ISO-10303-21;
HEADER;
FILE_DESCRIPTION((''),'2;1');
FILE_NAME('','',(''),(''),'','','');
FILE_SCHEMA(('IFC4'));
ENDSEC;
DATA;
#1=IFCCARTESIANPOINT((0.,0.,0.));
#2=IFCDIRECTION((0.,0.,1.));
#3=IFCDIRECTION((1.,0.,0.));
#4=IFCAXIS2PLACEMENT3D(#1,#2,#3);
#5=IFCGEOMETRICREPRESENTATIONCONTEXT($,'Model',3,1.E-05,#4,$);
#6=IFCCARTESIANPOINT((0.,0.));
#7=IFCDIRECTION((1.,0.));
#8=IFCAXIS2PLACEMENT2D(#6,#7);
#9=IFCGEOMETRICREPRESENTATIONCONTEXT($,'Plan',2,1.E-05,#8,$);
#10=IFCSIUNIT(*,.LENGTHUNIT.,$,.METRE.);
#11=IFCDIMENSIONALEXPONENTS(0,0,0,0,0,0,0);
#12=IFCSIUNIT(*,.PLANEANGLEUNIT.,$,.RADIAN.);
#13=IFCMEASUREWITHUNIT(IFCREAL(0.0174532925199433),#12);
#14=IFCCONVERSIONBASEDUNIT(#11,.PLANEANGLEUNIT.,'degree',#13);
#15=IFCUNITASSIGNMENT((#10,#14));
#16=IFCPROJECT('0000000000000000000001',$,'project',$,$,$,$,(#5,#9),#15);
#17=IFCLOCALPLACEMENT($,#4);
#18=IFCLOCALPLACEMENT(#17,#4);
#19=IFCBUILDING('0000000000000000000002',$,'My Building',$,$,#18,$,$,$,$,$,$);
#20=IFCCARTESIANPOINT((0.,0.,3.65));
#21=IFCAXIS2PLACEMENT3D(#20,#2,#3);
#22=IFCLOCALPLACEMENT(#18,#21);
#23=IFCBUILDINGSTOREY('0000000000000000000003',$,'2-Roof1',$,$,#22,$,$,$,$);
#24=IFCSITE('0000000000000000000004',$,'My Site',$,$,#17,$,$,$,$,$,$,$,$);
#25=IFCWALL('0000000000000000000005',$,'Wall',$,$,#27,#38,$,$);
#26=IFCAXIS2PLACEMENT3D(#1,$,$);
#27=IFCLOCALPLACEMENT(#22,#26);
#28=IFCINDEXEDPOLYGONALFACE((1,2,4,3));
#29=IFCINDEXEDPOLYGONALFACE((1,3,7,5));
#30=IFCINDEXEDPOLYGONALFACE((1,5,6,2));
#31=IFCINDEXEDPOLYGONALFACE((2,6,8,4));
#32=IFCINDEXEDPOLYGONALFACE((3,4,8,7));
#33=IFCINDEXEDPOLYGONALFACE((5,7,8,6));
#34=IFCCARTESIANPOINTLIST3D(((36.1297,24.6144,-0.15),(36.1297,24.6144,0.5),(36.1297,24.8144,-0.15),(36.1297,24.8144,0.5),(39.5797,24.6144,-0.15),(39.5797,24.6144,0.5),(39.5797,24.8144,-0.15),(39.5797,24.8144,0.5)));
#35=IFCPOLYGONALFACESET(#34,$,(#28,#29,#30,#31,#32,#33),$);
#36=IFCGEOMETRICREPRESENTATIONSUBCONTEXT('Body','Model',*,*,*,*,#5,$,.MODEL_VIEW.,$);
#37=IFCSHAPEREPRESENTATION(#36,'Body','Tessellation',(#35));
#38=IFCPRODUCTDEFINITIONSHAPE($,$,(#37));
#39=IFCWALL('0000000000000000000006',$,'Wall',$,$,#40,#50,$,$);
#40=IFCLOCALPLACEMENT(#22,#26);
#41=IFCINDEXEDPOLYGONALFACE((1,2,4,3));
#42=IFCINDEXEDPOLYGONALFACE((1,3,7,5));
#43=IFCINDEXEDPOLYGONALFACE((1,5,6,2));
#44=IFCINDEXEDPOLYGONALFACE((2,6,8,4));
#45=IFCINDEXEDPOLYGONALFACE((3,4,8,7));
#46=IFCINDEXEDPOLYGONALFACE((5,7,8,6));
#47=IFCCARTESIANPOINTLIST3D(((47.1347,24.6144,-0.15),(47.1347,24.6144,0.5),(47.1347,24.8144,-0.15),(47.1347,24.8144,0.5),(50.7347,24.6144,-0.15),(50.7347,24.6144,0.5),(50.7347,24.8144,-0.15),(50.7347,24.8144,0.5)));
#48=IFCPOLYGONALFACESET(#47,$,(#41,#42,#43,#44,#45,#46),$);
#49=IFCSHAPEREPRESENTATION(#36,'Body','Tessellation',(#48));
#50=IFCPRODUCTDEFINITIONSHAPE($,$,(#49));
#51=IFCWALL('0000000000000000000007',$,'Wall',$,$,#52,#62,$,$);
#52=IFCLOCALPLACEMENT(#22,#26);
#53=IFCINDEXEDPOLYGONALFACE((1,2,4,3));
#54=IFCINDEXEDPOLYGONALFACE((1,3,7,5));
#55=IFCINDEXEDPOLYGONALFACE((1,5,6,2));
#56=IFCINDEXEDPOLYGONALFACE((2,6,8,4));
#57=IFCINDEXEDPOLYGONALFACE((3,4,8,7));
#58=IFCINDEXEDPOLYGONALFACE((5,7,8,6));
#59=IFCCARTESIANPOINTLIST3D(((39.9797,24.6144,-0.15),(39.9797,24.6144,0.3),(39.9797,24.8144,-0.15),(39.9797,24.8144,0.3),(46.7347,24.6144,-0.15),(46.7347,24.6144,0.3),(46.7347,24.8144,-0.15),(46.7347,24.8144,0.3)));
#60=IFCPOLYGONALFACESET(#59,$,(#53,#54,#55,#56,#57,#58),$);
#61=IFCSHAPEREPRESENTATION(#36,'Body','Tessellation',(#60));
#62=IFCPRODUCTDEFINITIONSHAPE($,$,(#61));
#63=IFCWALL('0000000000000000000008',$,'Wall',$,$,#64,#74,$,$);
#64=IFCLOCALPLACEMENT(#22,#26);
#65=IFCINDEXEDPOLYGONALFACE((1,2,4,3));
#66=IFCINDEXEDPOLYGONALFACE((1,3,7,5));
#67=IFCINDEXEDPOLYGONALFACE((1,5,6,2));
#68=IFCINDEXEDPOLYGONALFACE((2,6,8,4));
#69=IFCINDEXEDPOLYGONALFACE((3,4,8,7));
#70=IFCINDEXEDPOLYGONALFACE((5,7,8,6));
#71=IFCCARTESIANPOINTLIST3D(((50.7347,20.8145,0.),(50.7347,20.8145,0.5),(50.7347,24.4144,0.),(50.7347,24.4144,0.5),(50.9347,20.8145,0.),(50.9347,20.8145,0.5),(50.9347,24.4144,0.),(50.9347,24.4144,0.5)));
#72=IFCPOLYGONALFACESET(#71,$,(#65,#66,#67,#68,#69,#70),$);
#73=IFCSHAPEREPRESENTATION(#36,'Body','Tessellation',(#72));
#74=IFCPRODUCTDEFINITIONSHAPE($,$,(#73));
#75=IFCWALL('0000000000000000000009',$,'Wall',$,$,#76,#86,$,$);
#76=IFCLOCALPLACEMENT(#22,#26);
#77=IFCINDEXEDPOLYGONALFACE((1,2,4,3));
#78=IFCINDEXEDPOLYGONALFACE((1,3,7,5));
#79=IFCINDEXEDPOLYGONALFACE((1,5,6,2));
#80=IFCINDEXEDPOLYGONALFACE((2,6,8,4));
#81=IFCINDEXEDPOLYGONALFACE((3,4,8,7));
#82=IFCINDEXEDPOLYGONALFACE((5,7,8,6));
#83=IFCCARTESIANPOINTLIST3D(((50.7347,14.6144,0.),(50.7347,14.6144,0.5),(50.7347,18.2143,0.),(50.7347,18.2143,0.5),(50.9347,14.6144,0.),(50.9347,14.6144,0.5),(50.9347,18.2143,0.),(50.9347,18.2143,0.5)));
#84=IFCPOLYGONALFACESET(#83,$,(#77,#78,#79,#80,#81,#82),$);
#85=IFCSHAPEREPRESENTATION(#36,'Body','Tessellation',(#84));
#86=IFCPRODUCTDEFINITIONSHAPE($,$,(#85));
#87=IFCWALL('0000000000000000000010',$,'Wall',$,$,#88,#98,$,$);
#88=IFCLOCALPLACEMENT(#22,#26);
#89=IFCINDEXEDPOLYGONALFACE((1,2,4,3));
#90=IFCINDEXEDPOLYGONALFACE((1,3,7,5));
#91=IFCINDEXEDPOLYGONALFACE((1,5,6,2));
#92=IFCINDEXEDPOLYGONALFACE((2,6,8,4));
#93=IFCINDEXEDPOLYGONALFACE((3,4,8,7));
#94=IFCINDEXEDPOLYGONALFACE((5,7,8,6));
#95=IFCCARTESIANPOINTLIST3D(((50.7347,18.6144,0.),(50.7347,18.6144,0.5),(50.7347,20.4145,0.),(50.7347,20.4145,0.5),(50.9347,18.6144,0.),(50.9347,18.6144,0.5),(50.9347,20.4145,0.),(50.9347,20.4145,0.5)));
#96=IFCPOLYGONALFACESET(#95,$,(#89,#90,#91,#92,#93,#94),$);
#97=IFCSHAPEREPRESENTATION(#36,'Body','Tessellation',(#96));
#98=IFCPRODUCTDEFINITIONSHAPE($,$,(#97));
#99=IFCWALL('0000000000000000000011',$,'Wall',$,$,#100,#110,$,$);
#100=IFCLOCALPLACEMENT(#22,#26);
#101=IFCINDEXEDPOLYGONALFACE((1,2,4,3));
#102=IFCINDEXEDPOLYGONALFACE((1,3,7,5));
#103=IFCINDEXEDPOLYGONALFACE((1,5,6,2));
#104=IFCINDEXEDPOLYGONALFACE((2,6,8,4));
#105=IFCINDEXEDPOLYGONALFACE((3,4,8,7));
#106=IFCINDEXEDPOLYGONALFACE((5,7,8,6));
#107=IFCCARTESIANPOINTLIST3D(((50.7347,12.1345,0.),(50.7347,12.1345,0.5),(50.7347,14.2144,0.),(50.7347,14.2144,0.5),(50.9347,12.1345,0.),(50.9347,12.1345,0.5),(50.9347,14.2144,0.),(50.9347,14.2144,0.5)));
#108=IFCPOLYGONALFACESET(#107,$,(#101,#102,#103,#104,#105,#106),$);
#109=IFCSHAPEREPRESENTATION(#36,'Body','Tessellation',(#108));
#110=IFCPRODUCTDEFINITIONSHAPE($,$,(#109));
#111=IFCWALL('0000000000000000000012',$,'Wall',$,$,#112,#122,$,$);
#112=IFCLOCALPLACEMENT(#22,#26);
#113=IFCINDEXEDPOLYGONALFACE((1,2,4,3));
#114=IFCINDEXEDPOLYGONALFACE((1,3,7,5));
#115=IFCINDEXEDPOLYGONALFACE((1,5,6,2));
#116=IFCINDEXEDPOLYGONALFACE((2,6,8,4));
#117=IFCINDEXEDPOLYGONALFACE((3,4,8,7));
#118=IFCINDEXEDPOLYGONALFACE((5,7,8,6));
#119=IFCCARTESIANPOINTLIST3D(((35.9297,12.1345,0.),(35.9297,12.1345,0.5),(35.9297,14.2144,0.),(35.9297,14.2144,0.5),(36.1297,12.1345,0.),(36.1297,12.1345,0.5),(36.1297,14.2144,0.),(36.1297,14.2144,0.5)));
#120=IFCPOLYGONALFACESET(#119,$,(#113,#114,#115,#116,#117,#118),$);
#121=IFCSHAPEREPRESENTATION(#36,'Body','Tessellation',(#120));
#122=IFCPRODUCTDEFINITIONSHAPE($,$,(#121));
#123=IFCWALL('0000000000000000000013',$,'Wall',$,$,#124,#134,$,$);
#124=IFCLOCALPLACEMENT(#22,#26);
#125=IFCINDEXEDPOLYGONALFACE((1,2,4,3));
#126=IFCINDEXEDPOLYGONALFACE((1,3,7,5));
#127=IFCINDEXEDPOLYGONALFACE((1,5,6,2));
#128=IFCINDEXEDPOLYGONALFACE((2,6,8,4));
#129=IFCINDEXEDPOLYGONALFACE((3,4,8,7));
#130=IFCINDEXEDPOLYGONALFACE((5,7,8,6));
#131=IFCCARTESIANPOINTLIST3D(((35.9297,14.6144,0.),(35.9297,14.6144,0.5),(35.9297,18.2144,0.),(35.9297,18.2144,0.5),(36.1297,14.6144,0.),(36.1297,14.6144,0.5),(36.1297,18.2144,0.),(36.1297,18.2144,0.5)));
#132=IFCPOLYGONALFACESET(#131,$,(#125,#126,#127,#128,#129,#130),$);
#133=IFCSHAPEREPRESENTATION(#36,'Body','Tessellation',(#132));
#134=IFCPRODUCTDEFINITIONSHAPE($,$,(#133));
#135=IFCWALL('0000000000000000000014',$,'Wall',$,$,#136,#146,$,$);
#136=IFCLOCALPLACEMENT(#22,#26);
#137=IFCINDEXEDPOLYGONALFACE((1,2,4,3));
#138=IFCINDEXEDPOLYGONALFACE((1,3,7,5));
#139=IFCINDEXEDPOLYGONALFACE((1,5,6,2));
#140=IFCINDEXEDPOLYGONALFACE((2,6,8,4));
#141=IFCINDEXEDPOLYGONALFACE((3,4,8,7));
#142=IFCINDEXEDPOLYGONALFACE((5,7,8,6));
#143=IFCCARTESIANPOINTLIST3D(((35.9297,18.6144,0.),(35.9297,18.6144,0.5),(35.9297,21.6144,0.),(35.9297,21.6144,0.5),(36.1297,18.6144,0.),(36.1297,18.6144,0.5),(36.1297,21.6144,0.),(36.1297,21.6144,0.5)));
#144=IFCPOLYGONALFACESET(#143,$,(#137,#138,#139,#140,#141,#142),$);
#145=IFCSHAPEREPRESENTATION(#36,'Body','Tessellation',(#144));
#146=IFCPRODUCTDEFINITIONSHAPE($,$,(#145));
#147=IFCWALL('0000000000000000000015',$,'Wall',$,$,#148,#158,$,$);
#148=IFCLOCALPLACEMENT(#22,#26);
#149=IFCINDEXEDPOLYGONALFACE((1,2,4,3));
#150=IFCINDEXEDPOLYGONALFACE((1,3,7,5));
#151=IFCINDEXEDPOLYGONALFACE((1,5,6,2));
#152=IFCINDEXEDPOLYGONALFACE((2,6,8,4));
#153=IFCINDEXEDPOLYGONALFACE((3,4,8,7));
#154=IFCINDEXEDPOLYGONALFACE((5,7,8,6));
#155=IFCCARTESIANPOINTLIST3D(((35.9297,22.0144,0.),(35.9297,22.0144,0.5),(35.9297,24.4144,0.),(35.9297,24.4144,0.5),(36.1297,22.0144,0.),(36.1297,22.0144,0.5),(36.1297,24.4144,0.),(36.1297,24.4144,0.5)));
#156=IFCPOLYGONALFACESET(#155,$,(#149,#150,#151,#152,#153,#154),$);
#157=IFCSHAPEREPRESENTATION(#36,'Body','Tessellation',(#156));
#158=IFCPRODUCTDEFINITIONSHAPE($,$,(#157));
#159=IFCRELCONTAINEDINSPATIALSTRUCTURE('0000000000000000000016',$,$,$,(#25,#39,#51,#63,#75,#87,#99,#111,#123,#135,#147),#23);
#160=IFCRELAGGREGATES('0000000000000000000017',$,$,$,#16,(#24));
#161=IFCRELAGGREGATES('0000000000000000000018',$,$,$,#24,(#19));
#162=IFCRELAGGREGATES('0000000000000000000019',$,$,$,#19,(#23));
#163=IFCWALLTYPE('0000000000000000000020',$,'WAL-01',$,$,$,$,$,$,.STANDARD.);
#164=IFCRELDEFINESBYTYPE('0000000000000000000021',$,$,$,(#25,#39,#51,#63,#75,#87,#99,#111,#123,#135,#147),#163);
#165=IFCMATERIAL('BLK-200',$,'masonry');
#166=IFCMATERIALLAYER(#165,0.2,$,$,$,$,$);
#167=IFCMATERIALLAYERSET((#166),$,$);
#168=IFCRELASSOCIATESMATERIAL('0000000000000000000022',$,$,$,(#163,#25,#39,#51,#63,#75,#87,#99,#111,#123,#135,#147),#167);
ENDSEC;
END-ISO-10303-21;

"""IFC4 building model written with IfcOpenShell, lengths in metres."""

from ifc_helpers import new_model, entity, si_unit, converted_unit, frame, origin_with_axes, origin_2d_with_axis, place, context, subcontext, project, spatial, indexed_curve, outline, extrude, material, layer, layer_set, layer_usage, type_object, element, save


model = new_model("IFC4")

# Units and contexts
model_context = context("Model", 3, precision=1e-05, world=origin_with_axes())
plan_context = context("Plan", 2, precision=1e-05, world=origin_2d_with_axis())
body_context = subcontext(model_context, "Body", "Model", "MODEL_VIEW")
ifc_project = project(units=[si_unit("LENGTHUNIT", "METRE"), converted_unit("PLANEANGLEUNIT", "degree", entity("IfcReal", 0.0174532925199433), si_unit("PLANEANGLEUNIT", "RADIAN"), dimensions=[0, 0, 0, 0, 0, 0, 0])], contexts=[model_context, plan_context])

# Site, building, storey
site_placement = place(None, origin_with_axes())
site = spatial("IfcSite", under=ifc_project, at=site_placement, Name="My Site")
building_placement = place(site_placement, origin_with_axes())
building = spatial("IfcBuilding", under=site, at=building_placement, Name="My Building")
storey_placement = place(building_placement, frame((0.0, 0.0, 3.65), z_axis=(0.0, 0.0, 1.0), x_axis=(1.0, 0.0, 0.0)))
storey = spatial("IfcBuildingStorey", under=building, at=storey_placement, Name="2-Roof1")

# Walls
ifc_material = material(Name="BLK-200", Category="masonry")
ifc_layer = layer(ifc_material, 0.2)
ifc_layer_set = layer_set([ifc_layer])
ifc_layer_usage_1 = layer_usage(ifc_layer_set, "AXIS2", "POSITIVE", 0.0)
wall_type = type_object("IfcWallType", Name="WAL-01", PredefinedType="STANDARD", material=ifc_layer_set)
wall_1_placement = place(storey_placement, frame((39.5797, 24.8144, -0.15), z_axis=(0.0, 0.0, 1.0), x_axis=(-1.0, 0.0, 0.0)))
element("IfcWall", 1, at=wall_1_placement, inside=storey, type_object=wall_type, material=ifc_layer_usage_1, Name="Wall", context=body_context, shape_type="SweptSolid", body=[
    extrude(outline(indexed_curve([(0.0, 0.0), (0.0, 0.2), (3.45, 0.2), (3.45, 0.0), (0.0, 0.0)], self_intersect=False)), origin_with_axes(), (0.0, 0.0, 1.0), 0.65),
])
ifc_layer_usage_2 = layer_usage(ifc_layer_set, "AXIS2", "POSITIVE", 0.0)
wall_2_placement = place(storey_placement, frame((50.7347, 24.8144, -0.15), z_axis=(0.0, 0.0, 1.0), x_axis=(-1.0, 0.0, 0.0)))
element("IfcWall", 2, at=wall_2_placement, inside=storey, type_object=wall_type, material=ifc_layer_usage_2, Name="Wall", context=body_context, shape_type="SweptSolid", body=[
    extrude(outline(indexed_curve([(0.0, 0.0), (0.0, 0.2), (3.6, 0.2), (3.6, 0.0), (0.0, 0.0)], self_intersect=False)), origin_with_axes(), (0.0, 0.0, 1.0), 0.65),
])
ifc_layer_usage_3 = layer_usage(ifc_layer_set, "AXIS2", "POSITIVE", 0.0)
wall_3_placement = place(storey_placement, frame((46.7347, 24.8144, -0.15), z_axis=(0.0, 0.0, 1.0), x_axis=(-1.0, 0.0, 0.0)))
element("IfcWall", 3, at=wall_3_placement, inside=storey, type_object=wall_type, material=ifc_layer_usage_3, Name="Wall", context=body_context, shape_type="SweptSolid", body=[
    extrude(outline(indexed_curve([(0.0, 0.0), (0.0, 0.2), (6.755, 0.2), (6.755, 0.0), (0.0, 0.0)], self_intersect=False)), origin_with_axes(), (0.0, 0.0, 1.0), 0.45),
])
ifc_layer_usage_4 = layer_usage(ifc_layer_set, "AXIS2", "POSITIVE", 0.0)
wall_4_placement = place(storey_placement, frame((50.7347, 24.4144, 0.0), z_axis=(0.0, 0.0, 1.0), x_axis=(-0.000001, -1.0, 0.0)))
element("IfcWall", 4, at=wall_4_placement, inside=storey, type_object=wall_type, material=ifc_layer_usage_4, Name="Wall", context=body_context, shape_type="SweptSolid", body=[
    extrude(outline(indexed_curve([(0.0, 0.0), (0.0, 0.2), (3.5999, 0.2), (3.5999, 0.0), (0.0, 0.0)], self_intersect=False)), origin_with_axes(), (0.0, 0.0, 1.0), 0.5),
])
ifc_layer_usage_5 = layer_usage(ifc_layer_set, "AXIS2", "POSITIVE", 0.0)
wall_5_placement = place(storey_placement, frame((50.7347, 18.2143, 0.0), z_axis=(0.0, 0.0, 1.0), x_axis=(-0.000001, -1.0, 0.0)))
element("IfcWall", 5, at=wall_5_placement, inside=storey, type_object=wall_type, material=ifc_layer_usage_5, Name="Wall", context=body_context, shape_type="SweptSolid", body=[
    extrude(outline(indexed_curve([(0.0, 0.0), (0.0, 0.2), (3.5999, 0.2), (3.5999, 0.0), (0.0, 0.0)], self_intersect=False)), origin_with_axes(), (0.0, 0.0, 1.0), 0.5),
])
ifc_layer_usage_6 = layer_usage(ifc_layer_set, "AXIS2", "POSITIVE", 0.0)
wall_6_placement = place(storey_placement, frame((50.7347, 20.4145, 0.0), z_axis=(0.0, 0.0, 1.0), x_axis=(-0.000001, -1.0, 0.0)))
element("IfcWall", 6, at=wall_6_placement, inside=storey, type_object=wall_type, material=ifc_layer_usage_6, Name="Wall", context=body_context, shape_type="SweptSolid", body=[
    extrude(outline(indexed_curve([(0.0, 0.0), (0.0, 0.2), (1.8001, 0.2), (1.8001, 0.0), (0.0, 0.0)], self_intersect=False)), origin_with_axes(), (0.0, 0.0, 1.0), 0.5),
])
ifc_layer_usage_7 = layer_usage(ifc_layer_set, "AXIS2", "POSITIVE", 0.0)
wall_7_placement = place(storey_placement, frame((50.7347, 14.2144, 0.0), z_axis=(0.0, 0.0, 1.0), x_axis=(-0.000001, -1.0, 0.0)))
element("IfcWall", 7, at=wall_7_placement, inside=storey, type_object=wall_type, material=ifc_layer_usage_7, Name="Wall", context=body_context, shape_type="SweptSolid", body=[
    extrude(outline(indexed_curve([(0.0, 0.0), (0.0, 0.2), (2.0799, 0.2), (2.0799, 0.0), (0.0, 0.0)], self_intersect=False)), origin_with_axes(), (0.0, 0.0, 1.0), 0.5),
])
ifc_layer_usage_8 = layer_usage(ifc_layer_set, "AXIS2", "POSITIVE", 0.0)
wall_8_placement = place(storey_placement, frame((35.9297, 14.2144, 0.0), z_axis=(0.0, 0.0, 1.0), x_axis=(-0.000001, -1.0, 0.0)))
element("IfcWall", 8, at=wall_8_placement, inside=storey, type_object=wall_type, material=ifc_layer_usage_8, Name="Wall", context=body_context, shape_type="SweptSolid", body=[
    extrude(outline(indexed_curve([(0.0, 0.0), (0.0, 0.2), (2.0799, 0.2), (2.0799, 0.0), (0.0, 0.0)], self_intersect=False)), origin_with_axes(), (0.0, 0.0, 1.0), 0.5),
])
ifc_layer_usage_9 = layer_usage(ifc_layer_set, "AXIS2", "POSITIVE", 0.0)
wall_9_placement = place(storey_placement, frame((35.9297, 18.2144, 0.0), z_axis=(0.0, 0.0, 1.0), x_axis=(-0.000001, -1.0, 0.0)))
element("IfcWall", 9, at=wall_9_placement, inside=storey, type_object=wall_type, material=ifc_layer_usage_9, Name="Wall", context=body_context, shape_type="SweptSolid", body=[
    extrude(outline(indexed_curve([(0.0, 0.0), (0.0, 0.2), (3.6, 0.2), (3.6, 0.0), (0.0, 0.0)], self_intersect=False)), origin_with_axes(), (0.0, 0.0, 1.0), 0.5),
])
ifc_layer_usage_10 = layer_usage(ifc_layer_set, "AXIS2", "POSITIVE", 0.0)
wall_10_placement = place(storey_placement, frame((35.9297, 21.6144, 0.0), z_axis=(0.0, 0.0, 1.0), x_axis=(-0.000001, -1.0, 0.0)))
element("IfcWall", 10, at=wall_10_placement, inside=storey, type_object=wall_type, material=ifc_layer_usage_10, Name="Wall", context=body_context, shape_type="SweptSolid", body=[
    extrude(outline(indexed_curve([(0.0, 0.0), (0.0, 0.2), (3.0, 0.2), (3.0, 0.0), (0.0, 0.0)], self_intersect=False)), origin_with_axes(), (0.0, 0.0, 1.0), 0.5),
])
ifc_layer_usage_11 = layer_usage(ifc_layer_set, "AXIS2", "POSITIVE", 0.0)
wall_11_placement = place(storey_placement, frame((35.9297, 24.4144, 0.0), z_axis=(0.0, 0.0, 1.0), x_axis=(-0.000001, -1.0, 0.0)))
element("IfcWall", 11, at=wall_11_placement, inside=storey, type_object=wall_type, material=ifc_layer_usage_11, Name="Wall", context=body_context, shape_type="SweptSolid", body=[
    extrude(outline(indexed_curve([(0.0, 0.0), (0.0, 0.2), (2.4, 0.2), (2.4, 0.0), (0.0, 0.0)], self_intersect=False)), origin_with_axes(), (0.0, 0.0, 1.0), 0.5),
])

save(model, "model.ifc")
